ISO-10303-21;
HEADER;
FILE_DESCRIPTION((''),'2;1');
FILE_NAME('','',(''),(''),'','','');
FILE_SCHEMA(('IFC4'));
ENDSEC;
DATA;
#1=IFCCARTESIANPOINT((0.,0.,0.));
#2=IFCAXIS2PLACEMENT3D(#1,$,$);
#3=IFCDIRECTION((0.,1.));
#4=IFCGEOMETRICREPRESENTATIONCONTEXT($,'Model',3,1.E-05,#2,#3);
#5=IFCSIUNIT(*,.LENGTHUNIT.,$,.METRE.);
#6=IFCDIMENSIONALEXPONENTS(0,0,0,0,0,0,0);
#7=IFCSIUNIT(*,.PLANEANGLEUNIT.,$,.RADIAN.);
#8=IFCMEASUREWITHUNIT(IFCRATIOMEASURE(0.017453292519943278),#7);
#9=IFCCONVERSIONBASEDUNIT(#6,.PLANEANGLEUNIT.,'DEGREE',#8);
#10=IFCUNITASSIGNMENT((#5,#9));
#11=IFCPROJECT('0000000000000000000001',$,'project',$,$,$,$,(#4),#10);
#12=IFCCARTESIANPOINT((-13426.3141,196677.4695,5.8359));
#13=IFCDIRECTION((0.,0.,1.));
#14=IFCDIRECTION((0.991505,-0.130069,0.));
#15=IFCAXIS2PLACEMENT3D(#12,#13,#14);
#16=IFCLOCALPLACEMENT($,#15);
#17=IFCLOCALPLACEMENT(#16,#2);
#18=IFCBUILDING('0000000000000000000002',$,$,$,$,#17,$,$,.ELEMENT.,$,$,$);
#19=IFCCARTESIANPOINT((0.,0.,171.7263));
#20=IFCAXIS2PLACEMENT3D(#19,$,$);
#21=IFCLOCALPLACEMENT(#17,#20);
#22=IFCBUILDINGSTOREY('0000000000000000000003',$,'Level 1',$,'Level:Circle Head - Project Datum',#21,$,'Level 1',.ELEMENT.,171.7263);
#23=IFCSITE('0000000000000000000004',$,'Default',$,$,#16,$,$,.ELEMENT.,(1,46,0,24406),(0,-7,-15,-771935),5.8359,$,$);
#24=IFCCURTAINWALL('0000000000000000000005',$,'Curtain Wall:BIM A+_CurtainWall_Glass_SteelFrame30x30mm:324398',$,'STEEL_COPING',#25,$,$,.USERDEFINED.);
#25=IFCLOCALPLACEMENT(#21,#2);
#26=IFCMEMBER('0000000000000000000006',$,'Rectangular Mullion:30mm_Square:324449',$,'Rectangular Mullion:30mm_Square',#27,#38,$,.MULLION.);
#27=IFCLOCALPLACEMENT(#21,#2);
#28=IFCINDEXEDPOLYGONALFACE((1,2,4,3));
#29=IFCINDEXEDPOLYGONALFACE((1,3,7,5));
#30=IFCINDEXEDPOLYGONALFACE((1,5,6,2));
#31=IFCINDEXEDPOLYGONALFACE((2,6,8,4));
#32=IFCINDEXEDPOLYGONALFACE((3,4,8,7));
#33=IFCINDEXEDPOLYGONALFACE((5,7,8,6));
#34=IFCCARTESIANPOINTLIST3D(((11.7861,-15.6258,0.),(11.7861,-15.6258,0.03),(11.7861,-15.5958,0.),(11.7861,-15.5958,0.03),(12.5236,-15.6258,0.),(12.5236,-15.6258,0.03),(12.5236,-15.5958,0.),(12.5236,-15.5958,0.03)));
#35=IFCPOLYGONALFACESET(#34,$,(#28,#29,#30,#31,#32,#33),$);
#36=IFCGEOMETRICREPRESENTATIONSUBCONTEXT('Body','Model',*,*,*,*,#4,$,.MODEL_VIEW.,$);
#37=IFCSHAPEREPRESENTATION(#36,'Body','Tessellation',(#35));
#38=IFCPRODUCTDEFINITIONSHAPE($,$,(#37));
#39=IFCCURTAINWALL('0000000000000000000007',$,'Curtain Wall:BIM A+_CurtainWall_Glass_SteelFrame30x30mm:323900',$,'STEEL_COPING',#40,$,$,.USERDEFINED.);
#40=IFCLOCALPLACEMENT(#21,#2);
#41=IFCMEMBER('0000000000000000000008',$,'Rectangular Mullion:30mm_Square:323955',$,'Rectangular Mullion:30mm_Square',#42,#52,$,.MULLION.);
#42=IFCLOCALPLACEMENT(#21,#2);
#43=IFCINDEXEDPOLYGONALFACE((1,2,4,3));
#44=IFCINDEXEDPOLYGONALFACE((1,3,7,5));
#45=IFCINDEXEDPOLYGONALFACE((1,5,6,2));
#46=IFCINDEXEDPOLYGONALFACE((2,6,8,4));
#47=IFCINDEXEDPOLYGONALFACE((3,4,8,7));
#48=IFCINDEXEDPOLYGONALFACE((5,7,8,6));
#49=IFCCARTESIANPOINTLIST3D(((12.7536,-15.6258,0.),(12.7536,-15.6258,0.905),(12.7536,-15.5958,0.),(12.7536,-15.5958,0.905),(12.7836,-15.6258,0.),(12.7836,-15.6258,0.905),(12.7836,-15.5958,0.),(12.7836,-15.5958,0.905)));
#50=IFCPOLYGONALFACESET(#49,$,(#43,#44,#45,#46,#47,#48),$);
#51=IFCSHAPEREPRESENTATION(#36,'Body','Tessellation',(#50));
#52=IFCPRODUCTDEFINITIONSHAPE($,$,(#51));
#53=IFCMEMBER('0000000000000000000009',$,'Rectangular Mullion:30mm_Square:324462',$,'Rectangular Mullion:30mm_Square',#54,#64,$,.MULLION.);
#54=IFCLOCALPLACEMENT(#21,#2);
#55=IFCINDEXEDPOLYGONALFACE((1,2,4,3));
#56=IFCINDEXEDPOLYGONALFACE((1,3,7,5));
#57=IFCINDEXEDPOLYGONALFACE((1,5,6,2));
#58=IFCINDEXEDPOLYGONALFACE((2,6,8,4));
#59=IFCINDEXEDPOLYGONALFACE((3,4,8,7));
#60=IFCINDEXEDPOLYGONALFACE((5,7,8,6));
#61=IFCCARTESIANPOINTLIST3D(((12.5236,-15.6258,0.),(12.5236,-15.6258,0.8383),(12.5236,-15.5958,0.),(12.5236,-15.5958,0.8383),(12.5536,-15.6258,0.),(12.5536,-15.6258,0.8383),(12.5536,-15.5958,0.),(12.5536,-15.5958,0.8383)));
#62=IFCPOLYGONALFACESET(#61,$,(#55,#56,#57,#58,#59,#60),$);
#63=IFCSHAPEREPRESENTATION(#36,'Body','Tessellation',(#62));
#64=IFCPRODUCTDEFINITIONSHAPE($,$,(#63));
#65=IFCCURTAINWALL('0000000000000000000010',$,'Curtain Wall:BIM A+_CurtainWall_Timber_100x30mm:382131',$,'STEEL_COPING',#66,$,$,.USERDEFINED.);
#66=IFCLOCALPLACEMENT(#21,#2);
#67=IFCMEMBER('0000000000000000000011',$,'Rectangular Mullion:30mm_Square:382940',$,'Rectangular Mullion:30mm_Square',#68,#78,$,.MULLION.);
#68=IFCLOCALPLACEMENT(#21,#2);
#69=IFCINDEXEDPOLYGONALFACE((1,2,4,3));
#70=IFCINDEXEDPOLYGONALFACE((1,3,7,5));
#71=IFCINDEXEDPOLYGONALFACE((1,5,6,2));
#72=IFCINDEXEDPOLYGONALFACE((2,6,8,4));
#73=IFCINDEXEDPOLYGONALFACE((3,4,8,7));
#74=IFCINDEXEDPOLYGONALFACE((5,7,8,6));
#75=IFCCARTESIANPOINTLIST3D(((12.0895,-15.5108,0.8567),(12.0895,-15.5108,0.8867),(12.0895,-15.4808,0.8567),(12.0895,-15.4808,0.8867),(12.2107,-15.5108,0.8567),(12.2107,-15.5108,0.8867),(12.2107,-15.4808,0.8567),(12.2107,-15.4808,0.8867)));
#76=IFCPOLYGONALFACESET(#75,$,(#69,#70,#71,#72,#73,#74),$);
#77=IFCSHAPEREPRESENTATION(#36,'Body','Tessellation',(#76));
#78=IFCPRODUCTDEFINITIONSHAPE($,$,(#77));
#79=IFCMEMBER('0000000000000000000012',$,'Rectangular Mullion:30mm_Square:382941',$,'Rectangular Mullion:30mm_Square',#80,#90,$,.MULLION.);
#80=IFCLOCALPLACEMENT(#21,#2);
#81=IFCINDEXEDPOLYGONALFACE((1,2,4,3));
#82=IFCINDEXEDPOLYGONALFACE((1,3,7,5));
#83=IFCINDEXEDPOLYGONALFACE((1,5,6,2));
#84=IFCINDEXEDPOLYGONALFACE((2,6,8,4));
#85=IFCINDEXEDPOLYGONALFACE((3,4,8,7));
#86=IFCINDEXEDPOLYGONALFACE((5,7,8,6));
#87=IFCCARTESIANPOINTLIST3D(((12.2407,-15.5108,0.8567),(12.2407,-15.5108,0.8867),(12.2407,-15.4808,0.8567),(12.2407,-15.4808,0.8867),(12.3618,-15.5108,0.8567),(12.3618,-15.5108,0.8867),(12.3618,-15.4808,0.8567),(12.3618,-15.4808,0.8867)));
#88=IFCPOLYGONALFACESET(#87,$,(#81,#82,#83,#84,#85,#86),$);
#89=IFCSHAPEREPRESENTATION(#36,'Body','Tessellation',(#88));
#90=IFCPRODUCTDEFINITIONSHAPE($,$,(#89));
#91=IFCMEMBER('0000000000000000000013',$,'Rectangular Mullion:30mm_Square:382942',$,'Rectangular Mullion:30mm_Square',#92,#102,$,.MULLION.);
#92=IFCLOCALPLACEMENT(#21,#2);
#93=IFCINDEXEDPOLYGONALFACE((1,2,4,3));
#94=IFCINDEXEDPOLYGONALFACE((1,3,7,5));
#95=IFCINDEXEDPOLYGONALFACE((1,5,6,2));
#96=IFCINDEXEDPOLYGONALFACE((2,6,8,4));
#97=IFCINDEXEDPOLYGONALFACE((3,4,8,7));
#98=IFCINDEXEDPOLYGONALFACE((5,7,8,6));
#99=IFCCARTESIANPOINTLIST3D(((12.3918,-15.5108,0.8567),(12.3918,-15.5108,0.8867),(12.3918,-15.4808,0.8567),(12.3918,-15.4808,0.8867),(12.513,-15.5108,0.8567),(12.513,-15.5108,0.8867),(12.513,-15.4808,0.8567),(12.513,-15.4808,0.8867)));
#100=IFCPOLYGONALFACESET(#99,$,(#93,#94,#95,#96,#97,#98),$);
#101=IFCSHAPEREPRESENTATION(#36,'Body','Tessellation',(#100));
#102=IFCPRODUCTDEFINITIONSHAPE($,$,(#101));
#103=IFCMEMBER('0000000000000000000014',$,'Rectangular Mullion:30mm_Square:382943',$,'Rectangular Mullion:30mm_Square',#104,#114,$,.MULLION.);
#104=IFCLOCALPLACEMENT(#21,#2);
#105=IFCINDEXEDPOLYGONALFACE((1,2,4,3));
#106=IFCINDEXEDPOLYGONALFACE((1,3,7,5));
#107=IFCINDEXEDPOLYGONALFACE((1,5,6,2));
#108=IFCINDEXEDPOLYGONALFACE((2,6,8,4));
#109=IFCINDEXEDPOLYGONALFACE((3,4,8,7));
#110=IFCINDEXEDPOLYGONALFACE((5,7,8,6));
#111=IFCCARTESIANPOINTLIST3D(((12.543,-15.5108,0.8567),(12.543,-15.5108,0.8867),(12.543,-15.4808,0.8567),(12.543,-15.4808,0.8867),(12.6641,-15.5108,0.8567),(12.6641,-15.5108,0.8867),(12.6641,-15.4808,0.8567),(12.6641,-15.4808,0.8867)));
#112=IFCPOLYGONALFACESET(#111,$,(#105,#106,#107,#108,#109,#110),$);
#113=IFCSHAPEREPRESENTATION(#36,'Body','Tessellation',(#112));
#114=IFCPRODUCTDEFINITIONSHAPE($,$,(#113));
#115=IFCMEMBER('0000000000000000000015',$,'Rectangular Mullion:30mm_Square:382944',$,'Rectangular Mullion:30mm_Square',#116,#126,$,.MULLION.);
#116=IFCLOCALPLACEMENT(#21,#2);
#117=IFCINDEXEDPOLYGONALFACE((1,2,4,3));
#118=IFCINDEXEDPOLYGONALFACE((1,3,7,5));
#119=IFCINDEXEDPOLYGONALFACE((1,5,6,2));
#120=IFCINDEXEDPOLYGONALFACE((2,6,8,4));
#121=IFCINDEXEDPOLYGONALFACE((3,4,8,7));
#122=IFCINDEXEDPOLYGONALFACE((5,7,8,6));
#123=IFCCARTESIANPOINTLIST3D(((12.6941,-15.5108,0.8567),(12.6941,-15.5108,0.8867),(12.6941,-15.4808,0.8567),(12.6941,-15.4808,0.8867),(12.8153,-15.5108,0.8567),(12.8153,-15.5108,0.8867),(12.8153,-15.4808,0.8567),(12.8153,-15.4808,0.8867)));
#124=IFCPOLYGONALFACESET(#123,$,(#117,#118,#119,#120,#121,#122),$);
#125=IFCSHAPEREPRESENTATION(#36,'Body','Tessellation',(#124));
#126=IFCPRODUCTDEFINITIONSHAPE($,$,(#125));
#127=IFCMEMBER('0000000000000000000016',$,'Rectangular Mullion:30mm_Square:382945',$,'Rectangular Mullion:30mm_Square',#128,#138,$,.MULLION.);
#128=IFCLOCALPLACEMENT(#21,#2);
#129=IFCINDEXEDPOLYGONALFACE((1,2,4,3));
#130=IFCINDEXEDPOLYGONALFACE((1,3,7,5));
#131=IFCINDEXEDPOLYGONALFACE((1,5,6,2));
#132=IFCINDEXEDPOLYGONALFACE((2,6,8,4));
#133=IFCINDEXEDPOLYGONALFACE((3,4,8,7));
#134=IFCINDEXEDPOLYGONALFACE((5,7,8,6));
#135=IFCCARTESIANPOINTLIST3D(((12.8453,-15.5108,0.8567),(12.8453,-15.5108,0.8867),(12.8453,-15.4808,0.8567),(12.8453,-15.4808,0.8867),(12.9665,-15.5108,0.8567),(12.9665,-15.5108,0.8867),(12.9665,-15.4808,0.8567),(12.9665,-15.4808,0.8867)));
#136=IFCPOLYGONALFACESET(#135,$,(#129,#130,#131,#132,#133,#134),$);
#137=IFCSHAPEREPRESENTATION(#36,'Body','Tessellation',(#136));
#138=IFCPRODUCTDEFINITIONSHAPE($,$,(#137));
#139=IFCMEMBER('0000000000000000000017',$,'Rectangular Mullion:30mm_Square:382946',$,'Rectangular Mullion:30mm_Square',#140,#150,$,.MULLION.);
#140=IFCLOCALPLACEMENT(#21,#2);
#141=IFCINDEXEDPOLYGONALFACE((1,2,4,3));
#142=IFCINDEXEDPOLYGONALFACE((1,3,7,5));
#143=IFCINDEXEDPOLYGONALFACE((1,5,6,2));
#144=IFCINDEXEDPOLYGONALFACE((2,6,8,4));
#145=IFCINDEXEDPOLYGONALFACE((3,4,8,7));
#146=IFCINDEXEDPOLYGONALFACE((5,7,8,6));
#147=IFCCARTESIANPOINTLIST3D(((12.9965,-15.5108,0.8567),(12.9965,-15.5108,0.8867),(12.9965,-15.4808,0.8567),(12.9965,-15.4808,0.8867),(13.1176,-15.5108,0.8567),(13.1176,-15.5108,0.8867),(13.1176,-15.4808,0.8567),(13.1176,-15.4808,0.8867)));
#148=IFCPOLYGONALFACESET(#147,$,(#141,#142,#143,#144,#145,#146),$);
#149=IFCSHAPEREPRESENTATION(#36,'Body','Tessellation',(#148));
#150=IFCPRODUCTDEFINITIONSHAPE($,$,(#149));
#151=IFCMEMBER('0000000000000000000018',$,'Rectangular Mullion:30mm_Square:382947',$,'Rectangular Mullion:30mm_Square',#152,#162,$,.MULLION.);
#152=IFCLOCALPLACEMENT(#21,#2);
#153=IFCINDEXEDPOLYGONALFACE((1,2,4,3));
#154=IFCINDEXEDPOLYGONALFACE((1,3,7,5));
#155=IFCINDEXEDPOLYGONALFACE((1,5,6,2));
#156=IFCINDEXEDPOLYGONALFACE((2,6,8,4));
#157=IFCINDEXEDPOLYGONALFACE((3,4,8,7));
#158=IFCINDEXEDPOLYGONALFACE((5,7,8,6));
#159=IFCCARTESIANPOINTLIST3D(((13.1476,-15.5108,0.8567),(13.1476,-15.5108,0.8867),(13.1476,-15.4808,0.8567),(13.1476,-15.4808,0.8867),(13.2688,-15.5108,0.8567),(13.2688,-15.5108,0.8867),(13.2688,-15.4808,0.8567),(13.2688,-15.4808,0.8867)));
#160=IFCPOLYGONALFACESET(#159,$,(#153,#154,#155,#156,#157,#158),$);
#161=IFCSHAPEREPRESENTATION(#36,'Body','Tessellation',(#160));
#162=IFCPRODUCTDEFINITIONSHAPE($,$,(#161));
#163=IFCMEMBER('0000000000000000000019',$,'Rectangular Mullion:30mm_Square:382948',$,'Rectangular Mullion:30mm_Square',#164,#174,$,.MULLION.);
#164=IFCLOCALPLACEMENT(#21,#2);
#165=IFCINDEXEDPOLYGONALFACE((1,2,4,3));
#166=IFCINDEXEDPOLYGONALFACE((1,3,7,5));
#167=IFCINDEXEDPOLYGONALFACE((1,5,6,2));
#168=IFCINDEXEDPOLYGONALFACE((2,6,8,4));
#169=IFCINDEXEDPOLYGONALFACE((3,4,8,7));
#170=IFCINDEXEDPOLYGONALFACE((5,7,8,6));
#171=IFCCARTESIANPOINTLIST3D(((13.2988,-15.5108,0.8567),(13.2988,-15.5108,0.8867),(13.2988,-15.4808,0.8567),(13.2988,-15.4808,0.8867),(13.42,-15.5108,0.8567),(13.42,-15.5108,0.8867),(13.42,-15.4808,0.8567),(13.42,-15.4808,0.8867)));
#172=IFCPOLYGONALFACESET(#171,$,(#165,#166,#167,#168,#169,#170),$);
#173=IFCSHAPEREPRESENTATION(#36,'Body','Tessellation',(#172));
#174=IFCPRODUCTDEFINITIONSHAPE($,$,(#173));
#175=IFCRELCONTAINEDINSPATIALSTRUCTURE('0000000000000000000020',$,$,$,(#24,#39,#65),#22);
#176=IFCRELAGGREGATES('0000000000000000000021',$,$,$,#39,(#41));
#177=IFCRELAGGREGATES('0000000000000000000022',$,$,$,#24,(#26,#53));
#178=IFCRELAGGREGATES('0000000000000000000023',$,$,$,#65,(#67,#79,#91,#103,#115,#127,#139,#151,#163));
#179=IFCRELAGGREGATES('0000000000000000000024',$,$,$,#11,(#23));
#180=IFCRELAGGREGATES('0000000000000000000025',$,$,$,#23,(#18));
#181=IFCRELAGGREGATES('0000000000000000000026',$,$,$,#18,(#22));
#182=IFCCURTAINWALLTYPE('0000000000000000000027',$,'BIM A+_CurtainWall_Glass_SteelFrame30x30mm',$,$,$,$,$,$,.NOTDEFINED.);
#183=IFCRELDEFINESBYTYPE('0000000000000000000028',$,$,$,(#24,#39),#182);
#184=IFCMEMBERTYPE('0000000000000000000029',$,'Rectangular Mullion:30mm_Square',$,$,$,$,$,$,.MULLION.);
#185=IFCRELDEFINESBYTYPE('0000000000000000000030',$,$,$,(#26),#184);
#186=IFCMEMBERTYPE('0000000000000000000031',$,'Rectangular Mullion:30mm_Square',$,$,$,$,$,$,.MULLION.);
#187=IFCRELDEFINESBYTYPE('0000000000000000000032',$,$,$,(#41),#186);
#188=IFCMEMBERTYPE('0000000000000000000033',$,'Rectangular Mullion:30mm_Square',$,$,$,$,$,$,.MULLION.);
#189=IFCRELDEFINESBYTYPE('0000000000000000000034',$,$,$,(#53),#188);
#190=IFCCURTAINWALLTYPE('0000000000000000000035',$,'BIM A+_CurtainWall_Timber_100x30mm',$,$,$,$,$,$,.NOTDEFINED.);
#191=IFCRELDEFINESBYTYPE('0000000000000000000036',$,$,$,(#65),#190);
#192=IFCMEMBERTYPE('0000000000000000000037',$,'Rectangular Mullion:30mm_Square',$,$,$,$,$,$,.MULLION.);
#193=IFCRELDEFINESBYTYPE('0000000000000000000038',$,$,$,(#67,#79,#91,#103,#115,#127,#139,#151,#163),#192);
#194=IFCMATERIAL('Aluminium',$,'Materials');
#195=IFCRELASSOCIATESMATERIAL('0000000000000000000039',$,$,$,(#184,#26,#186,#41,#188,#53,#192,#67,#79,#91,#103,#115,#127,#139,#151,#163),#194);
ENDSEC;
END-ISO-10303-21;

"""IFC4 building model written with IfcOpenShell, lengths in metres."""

from ifc_helpers import new_model, entity, si_unit, converted_unit, direction, frame, origin, place, context, subcontext, project, spatial, indexed_curve, outline, extrude, source, transform, mapped, material, type_object, type_shapes, element, aggregate, save


model = new_model("IFC4")

# Units and contexts
model_context = context("Model", 3, precision=1e-05, world=origin(), true_north=direction((0.0, 1.0)))
body_context = subcontext(model_context, "Body", "Model", "MODEL_VIEW")
ifc_project = project(units=[si_unit("LENGTHUNIT", "METRE"), converted_unit("PLANEANGLEUNIT", "DEGREE", entity("IfcRatioMeasure", 0.017453292519943278), si_unit("PLANEANGLEUNIT", "RADIAN"), dimensions=[0, 0, 0, 0, 0, 0, 0])], contexts=[model_context])

# Site, building, storey
site_placement = place(None, frame((-13426.3141, 196677.4695, 5.8359), z_axis=(0.0, 0.0, 1.0), x_axis=(0.991505, -0.130069, 0.0)))
site = spatial("IfcSite", under=ifc_project, at=site_placement, Name="Default", CompositionType="ELEMENT", RefLatitude=(1, 46, 0, 24406), RefLongitude=(0, -7, -15, -771935), RefElevation=5.8359)
building_placement = place(site_placement, origin())
building = spatial("IfcBuilding", under=site, at=building_placement, CompositionType="ELEMENT")
storey_placement = place(building_placement, frame((0.0, 0.0, 171.7263)))
storey = spatial("IfcBuildingStorey", under=building, at=storey_placement, Name="Level 1", ObjectType="Level:Circle Head - Project Datum", LongName="Level 1", CompositionType="ELEMENT", Elevation=171.7263)

# Curtain walls, members
curtain_wall_type_1 = type_object("IfcCurtainWallType", Name="BIM A+_CurtainWall_Glass_SteelFrame30x30mm", PredefinedType="NOTDEFINED")
curtain_wall_1_placement = place(storey_placement, frame((0.0, 0.0, -171.7263)))
curtain_wall_1 = element("IfcCurtainWall", 1, at=curtain_wall_1_placement, inside=storey, type_object=curtain_wall_type_1, Name="Curtain Wall:BIM A+_CurtainWall_Glass_SteelFrame30x30mm:324398", ObjectType="STEEL_COPING", PredefinedType="USERDEFINED")
ifc_material_1 = material(Name="Aluminium", Category="Materials")
member_type_1 = type_object("IfcMemberType", Name="Rectangular Mullion:30mm_Square", PredefinedType="MULLION", material=ifc_material_1)
shared_shape_1 = source(origin(), body_context, "Body", "SweptSolid", [
    extrude(outline(indexed_curve([(-0.015, -0.015), (0.015, -0.015), (0.015, 0.015), (-0.015, 0.015), (-0.015, -0.015)], self_intersect=False)), frame((-0.015, 0.0, -0.7375), z_axis=(0.0, 0.0, 1.0), x_axis=(0.0, -1.0, 0.0)), (0.0, 0.0, 1.0), 0.7375),
])
type_shapes(member_type_1, [shared_shape_1])
member_1_placement = place(curtain_wall_1_placement, frame((12.5236, -15.6108, 171.7263), z_axis=(1.0, 0.0, 0.0), x_axis=(0.0, 0.0, -1.0)))
member_1 = element("IfcMember", 2, at=member_1_placement, type_object=member_type_1, material=ifc_material_1, Name="Rectangular Mullion:30mm_Square:324449", ObjectType="Rectangular Mullion:30mm_Square", PredefinedType="MULLION", context=body_context, shape_type="MappedRepresentation", body=[
    mapped(shared_shape_1, transform((0.0, 0.0, 0.0), scale=1.0)),
])
curtain_wall_2_placement = place(storey_placement, frame((0.0, 0.0, -171.7263)))
curtain_wall_2 = element("IfcCurtainWall", 3, at=curtain_wall_2_placement, inside=storey, type_object=curtain_wall_type_1, Name="Curtain Wall:BIM A+_CurtainWall_Glass_SteelFrame30x30mm:323900", ObjectType="STEEL_COPING", PredefinedType="USERDEFINED")
member_type_2 = type_object("IfcMemberType", Name="Rectangular Mullion:30mm_Square", PredefinedType="MULLION", material=ifc_material_1)
shared_shape_2 = source(origin(), body_context, "Body", "SweptSolid", [
    extrude(outline(indexed_curve([(-0.015, -0.015), (0.015, -0.015), (0.015, 0.015), (-0.015, 0.015), (-0.015, -0.015)], self_intersect=False)), frame((-0.015, 0.0, -0.905), z_axis=(0.0, 0.0, 1.0), x_axis=(0.0, -1.0, 0.0)), (0.0, 0.0, 1.0), 0.905),
])
type_shapes(member_type_2, [shared_shape_2])
member_2_placement = place(curtain_wall_2_placement, frame((12.7536, -15.6108, 171.7263), z_axis=(0.0, 0.0, -1.0), x_axis=(-1.0, 0.0, 0.0)))
member_2 = element("IfcMember", 4, at=member_2_placement, type_object=member_type_2, material=ifc_material_1, Name="Rectangular Mullion:30mm_Square:323955", ObjectType="Rectangular Mullion:30mm_Square", PredefinedType="MULLION", context=body_context, shape_type="MappedRepresentation", body=[
    mapped(shared_shape_2, transform((0.0, 0.0, 0.0), scale=1.0)),
])
aggregate(curtain_wall_2, [member_2])

# Member
member_type_3 = type_object("IfcMemberType", Name="Rectangular Mullion:30mm_Square", PredefinedType="MULLION", material=ifc_material_1)
shared_shape_3 = source(origin(), body_context, "Body", "SweptSolid", [
    extrude(outline(indexed_curve([(-0.015, -0.015), (0.015, -0.015), (0.015, 0.015), (-0.015, 0.015), (-0.015, -0.015)], self_intersect=False)), frame((-0.015, 0.0, -0.8383), z_axis=(0.0, 0.0, 1.0), x_axis=(0.0, -1.0, 0.0)), (0.0, 0.0, 1.0), 0.8383),
])
type_shapes(member_type_3, [shared_shape_3])
member_3_placement = place(curtain_wall_1_placement, frame((12.5536, -15.6108, 172.5646)))
member_3 = element("IfcMember", 5, at=member_3_placement, type_object=member_type_3, material=ifc_material_1, Name="Rectangular Mullion:30mm_Square:324462", ObjectType="Rectangular Mullion:30mm_Square", PredefinedType="MULLION", context=body_context, shape_type="MappedRepresentation", body=[
    mapped(shared_shape_3, transform((0.0, 0.0, 0.0), scale=1.0)),
])

# Curtain wall, members
curtain_wall_type_2 = type_object("IfcCurtainWallType", Name="BIM A+_CurtainWall_Timber_100x30mm", PredefinedType="NOTDEFINED")
curtain_wall_3_placement = place(storey_placement, frame((0.0, 0.0, -171.7263)))
curtain_wall_3 = element("IfcCurtainWall", 6, at=curtain_wall_3_placement, inside=storey, type_object=curtain_wall_type_2, Name="Curtain Wall:BIM A+_CurtainWall_Timber_100x30mm:382131", ObjectType="STEEL_COPING", PredefinedType="USERDEFINED")
member_type_4 = type_object("IfcMemberType", Name="Rectangular Mullion:30mm_Square", PredefinedType="MULLION", material=ifc_material_1)
shared_shape_4 = source(origin(), body_context, "Body", "SweptSolid", [
    extrude(outline(indexed_curve([(-0.015, -0.015), (0.015, -0.015), (0.015, 0.015), (-0.015, 0.015), (-0.015, -0.015)], self_intersect=False)), frame((0.0, 0.0, -0.1212), z_axis=(0.0, 0.0, 1.0), x_axis=(0.0, -1.0, 0.0)), (0.0, 0.0, 1.0), 0.1212),
])
type_shapes(member_type_4, [shared_shape_4])
member_4_placement = place(curtain_wall_3_placement, frame((12.2107, -15.4958, 172.598), z_axis=(1.0, 0.0, 0.0), x_axis=(0.0, 0.0, 1.0)))
member_4 = element("IfcMember", 7, at=member_4_placement, type_object=member_type_4, material=ifc_material_1, Name="Rectangular Mullion:30mm_Square:382940", ObjectType="Rectangular Mullion:30mm_Square", PredefinedType="MULLION", context=body_context, shape_type="MappedRepresentation", body=[
    mapped(shared_shape_4, transform((0.0, 0.0, 0.0), scale=1.0)),
])
member_5_placement = place(curtain_wall_3_placement, frame((12.3618, -15.4958, 172.598), z_axis=(1.0, 0.0, 0.0), x_axis=(0.0, 0.0, 1.0)))
member_5 = element("IfcMember", 8, at=member_5_placement, type_object=member_type_4, material=ifc_material_1, Name="Rectangular Mullion:30mm_Square:382941", ObjectType="Rectangular Mullion:30mm_Square", PredefinedType="MULLION", context=body_context, shape_type="MappedRepresentation", body=[
    mapped(shared_shape_4, transform((0.0, 0.0, 0.0), scale=1.0)),
])
member_6_placement = place(curtain_wall_3_placement, frame((12.513, -15.4958, 172.598), z_axis=(1.0, 0.0, 0.0), x_axis=(0.0, 0.0, 1.0)))
member_6 = element("IfcMember", 9, at=member_6_placement, type_object=member_type_4, material=ifc_material_1, Name="Rectangular Mullion:30mm_Square:382942", ObjectType="Rectangular Mullion:30mm_Square", PredefinedType="MULLION", context=body_context, shape_type="MappedRepresentation", body=[
    mapped(shared_shape_4, transform((0.0, 0.0, 0.0), scale=1.0)),
])
member_7_placement = place(curtain_wall_3_placement, frame((12.6641, -15.4958, 172.598), z_axis=(1.0, 0.0, 0.0), x_axis=(0.0, 0.0, 1.0)))
member_7 = element("IfcMember", 10, at=member_7_placement, type_object=member_type_4, material=ifc_material_1, Name="Rectangular Mullion:30mm_Square:382943", ObjectType="Rectangular Mullion:30mm_Square", PredefinedType="MULLION", context=body_context, shape_type="MappedRepresentation", body=[
    mapped(shared_shape_4, transform((0.0, 0.0, 0.0), scale=1.0)),
])
member_8_placement = place(curtain_wall_3_placement, frame((12.8153, -15.4958, 172.598), z_axis=(1.0, 0.0, 0.0), x_axis=(0.0, 0.0, 1.0)))
member_8 = element("IfcMember", 11, at=member_8_placement, type_object=member_type_4, material=ifc_material_1, Name="Rectangular Mullion:30mm_Square:382944", ObjectType="Rectangular Mullion:30mm_Square", PredefinedType="MULLION", context=body_context, shape_type="MappedRepresentation", body=[
    mapped(shared_shape_4, transform((0.0, 0.0, 0.0), scale=1.0)),
])
member_9_placement = place(curtain_wall_3_placement, frame((12.9665, -15.4958, 172.598), z_axis=(1.0, 0.0, 0.0), x_axis=(0.0, 0.0, 1.0)))
member_9 = element("IfcMember", 12, at=member_9_placement, type_object=member_type_4, material=ifc_material_1, Name="Rectangular Mullion:30mm_Square:382945", ObjectType="Rectangular Mullion:30mm_Square", PredefinedType="MULLION", context=body_context, shape_type="MappedRepresentation", body=[
    mapped(shared_shape_4, transform((0.0, 0.0, 0.0), scale=1.0)),
])
member_10_placement = place(curtain_wall_3_placement, frame((13.1176, -15.4958, 172.598), z_axis=(1.0, 0.0, 0.0), x_axis=(0.0, 0.0, 1.0)))
member_10 = element("IfcMember", 13, at=member_10_placement, type_object=member_type_4, material=ifc_material_1, Name="Rectangular Mullion:30mm_Square:382946", ObjectType="Rectangular Mullion:30mm_Square", PredefinedType="MULLION", context=body_context, shape_type="MappedRepresentation", body=[
    mapped(shared_shape_4, transform((0.0, 0.0, 0.0), scale=1.0)),
])
member_11_placement = place(curtain_wall_3_placement, frame((13.2688, -15.4958, 172.598), z_axis=(1.0, 0.0, 0.0), x_axis=(0.0, 0.0, 1.0)))
member_11 = element("IfcMember", 14, at=member_11_placement, type_object=member_type_4, material=ifc_material_1, Name="Rectangular Mullion:30mm_Square:382947", ObjectType="Rectangular Mullion:30mm_Square", PredefinedType="MULLION", context=body_context, shape_type="MappedRepresentation", body=[
    mapped(shared_shape_4, transform((0.0, 0.0, 0.0), scale=1.0)),
])
member_12_placement = place(curtain_wall_3_placement, frame((13.42, -15.4958, 172.598), z_axis=(1.0, 0.0, 0.0), x_axis=(0.0, 0.0, 1.0)))
member_12 = element("IfcMember", 15, at=member_12_placement, type_object=member_type_4, material=ifc_material_1, Name="Rectangular Mullion:30mm_Square:382948", ObjectType="Rectangular Mullion:30mm_Square", PredefinedType="MULLION", context=body_context, shape_type="MappedRepresentation", body=[
    mapped(shared_shape_4, transform((0.0, 0.0, 0.0), scale=1.0)),
])

aggregate(curtain_wall_1, [member_1, member_3])
aggregate(curtain_wall_3, [member_4, member_5, member_6, member_7, member_8, member_9, member_10, member_11, member_12])

save(model, "model.ifc")
